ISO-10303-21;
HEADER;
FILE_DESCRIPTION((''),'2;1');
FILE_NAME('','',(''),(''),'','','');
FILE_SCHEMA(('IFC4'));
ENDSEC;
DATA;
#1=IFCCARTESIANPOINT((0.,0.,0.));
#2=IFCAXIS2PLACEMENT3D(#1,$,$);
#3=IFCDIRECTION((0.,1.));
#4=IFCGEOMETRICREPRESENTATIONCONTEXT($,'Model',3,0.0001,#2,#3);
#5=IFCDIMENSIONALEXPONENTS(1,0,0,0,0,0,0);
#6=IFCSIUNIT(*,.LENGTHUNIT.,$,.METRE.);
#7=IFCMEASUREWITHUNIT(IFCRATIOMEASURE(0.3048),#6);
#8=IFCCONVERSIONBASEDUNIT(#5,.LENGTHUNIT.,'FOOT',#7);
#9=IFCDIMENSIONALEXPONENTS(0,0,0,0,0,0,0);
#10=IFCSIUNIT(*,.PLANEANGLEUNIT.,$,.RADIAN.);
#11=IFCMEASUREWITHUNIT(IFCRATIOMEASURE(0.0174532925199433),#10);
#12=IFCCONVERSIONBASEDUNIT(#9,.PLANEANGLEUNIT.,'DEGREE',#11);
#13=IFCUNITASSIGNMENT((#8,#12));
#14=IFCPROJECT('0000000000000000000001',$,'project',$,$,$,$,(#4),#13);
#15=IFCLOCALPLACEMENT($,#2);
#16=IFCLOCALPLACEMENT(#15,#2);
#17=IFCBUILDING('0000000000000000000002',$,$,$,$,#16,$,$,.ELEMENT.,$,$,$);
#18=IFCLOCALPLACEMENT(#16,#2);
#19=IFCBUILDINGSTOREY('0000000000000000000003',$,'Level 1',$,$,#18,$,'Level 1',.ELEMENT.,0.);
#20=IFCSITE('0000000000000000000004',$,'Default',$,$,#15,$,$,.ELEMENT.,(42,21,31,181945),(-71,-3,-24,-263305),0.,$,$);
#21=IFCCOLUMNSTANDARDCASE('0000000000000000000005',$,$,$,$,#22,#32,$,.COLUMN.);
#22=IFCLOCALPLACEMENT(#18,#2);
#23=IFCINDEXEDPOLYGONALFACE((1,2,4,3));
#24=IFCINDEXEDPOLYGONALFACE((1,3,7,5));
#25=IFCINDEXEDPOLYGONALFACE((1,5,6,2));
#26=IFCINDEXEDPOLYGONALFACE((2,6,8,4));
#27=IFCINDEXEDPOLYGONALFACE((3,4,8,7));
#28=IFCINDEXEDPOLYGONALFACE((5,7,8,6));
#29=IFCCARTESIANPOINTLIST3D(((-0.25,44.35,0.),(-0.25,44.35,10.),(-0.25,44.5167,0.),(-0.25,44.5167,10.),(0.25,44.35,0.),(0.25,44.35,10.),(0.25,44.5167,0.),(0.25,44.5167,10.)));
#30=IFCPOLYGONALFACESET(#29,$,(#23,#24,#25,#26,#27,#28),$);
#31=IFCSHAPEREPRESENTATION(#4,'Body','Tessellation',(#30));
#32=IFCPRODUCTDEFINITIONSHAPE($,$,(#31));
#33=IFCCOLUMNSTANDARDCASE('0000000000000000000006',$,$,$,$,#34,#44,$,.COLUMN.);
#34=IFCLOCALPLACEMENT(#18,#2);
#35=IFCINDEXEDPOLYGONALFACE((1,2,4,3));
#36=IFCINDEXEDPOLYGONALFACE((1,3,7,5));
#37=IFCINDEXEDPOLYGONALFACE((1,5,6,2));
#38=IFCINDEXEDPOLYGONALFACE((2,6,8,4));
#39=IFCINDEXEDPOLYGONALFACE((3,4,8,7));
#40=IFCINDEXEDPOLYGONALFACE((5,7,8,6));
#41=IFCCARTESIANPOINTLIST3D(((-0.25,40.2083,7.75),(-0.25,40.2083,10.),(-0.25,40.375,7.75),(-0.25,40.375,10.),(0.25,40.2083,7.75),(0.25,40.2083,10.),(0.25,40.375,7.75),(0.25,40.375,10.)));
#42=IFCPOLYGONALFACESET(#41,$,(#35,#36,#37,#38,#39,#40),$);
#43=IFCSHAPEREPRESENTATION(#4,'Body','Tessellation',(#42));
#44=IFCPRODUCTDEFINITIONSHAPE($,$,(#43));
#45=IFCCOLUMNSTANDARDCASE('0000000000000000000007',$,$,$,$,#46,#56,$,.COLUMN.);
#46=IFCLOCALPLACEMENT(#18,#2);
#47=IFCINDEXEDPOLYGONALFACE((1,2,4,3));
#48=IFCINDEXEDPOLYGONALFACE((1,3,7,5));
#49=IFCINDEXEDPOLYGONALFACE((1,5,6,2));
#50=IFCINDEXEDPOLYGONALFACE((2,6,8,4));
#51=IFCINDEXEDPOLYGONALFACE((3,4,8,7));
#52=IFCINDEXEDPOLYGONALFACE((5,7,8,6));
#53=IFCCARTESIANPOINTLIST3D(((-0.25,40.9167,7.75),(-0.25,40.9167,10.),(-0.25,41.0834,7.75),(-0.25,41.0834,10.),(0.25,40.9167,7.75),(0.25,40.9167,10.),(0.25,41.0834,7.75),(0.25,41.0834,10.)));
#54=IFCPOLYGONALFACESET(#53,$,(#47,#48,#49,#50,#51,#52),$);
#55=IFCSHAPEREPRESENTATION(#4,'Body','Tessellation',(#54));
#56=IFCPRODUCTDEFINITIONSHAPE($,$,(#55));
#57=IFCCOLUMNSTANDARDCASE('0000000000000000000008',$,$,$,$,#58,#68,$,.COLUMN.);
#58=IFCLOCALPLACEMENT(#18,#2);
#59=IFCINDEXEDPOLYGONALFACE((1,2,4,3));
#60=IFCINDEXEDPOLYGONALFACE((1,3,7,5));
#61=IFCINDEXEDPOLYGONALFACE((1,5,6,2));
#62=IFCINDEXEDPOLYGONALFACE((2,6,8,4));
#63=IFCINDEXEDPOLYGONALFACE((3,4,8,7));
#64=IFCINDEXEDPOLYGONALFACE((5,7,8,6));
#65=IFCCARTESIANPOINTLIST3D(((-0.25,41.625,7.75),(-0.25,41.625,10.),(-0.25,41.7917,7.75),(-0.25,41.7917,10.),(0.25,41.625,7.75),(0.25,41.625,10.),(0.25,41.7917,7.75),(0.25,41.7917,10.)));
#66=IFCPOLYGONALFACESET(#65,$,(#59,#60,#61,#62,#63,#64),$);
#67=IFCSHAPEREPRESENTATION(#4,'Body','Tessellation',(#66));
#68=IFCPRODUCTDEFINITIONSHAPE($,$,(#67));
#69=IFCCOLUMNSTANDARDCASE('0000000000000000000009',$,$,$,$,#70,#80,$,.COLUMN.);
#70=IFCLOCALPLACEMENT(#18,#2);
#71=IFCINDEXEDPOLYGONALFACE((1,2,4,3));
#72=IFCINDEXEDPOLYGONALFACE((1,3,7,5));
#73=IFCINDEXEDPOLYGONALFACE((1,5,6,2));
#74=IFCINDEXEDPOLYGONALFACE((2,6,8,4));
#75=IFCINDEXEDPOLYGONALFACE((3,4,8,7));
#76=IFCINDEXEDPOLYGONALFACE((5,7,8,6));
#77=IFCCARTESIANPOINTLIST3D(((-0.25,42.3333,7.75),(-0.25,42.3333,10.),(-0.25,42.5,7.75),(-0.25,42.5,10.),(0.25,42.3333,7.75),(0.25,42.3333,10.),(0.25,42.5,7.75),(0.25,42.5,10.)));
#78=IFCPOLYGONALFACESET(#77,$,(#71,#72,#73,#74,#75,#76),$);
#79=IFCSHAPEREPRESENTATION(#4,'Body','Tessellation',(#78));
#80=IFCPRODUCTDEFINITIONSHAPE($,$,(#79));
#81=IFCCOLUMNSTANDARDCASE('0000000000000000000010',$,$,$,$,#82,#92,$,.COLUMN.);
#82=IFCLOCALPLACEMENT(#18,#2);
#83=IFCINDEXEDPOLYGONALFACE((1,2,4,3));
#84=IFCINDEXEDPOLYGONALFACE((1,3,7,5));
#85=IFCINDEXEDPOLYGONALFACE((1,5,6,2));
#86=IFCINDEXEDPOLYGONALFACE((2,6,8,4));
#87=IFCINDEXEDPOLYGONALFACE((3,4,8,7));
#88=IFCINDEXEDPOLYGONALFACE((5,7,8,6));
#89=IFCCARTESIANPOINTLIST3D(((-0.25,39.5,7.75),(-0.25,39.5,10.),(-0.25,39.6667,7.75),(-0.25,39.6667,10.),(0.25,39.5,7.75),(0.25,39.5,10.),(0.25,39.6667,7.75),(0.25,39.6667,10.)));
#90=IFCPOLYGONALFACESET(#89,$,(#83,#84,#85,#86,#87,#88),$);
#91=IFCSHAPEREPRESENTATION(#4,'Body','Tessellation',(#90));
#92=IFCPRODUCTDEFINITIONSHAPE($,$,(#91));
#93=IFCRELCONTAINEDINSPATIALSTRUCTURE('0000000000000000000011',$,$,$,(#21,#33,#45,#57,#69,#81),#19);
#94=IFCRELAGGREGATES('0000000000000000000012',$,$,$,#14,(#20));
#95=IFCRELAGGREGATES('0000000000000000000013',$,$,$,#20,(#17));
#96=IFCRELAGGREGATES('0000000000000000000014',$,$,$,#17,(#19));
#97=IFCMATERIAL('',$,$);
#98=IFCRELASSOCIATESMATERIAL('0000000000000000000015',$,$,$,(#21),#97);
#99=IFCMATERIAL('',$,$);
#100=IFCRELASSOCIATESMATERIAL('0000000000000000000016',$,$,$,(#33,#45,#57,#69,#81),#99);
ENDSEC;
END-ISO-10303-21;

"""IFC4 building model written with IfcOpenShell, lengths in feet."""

from ifc_helpers import new_model, entity, si_unit, converted_unit, direction, frame, origin, place, context, project, spatial, rectangle, extrude, material, element, save


model = new_model("IFC4")

# Units and contexts
model_context = context("Model", 3, precision=0.0001, world=origin(), true_north=direction((0.0, 1.0)))
ifc_project = project(units=[converted_unit("LENGTHUNIT", "FOOT", entity("IfcRatioMeasure", 0.3048), si_unit("LENGTHUNIT", "METRE"), dimensions=[1, 0, 0, 0, 0, 0, 0]), converted_unit("PLANEANGLEUNIT", "DEGREE", entity("IfcRatioMeasure", 0.0174532925199433), si_unit("PLANEANGLEUNIT", "RADIAN"), dimensions=[0, 0, 0, 0, 0, 0, 0])], contexts=[model_context])

# Site, building, storey
site_placement = place(None, origin())
site = spatial("IfcSite", under=ifc_project, at=site_placement, Name="Default", CompositionType="ELEMENT", RefLatitude=(42, 21, 31, 181945), RefLongitude=(-71, -3, -24, -263305), RefElevation=0.0)
building_placement = place(site_placement, origin())
building = spatial("IfcBuilding", under=site, at=building_placement, CompositionType="ELEMENT")
storey_placement = place(building_placement, origin())
storey = spatial("IfcBuildingStorey", under=building, at=storey_placement, Name="Level 1", LongName="Level 1", CompositionType="ELEMENT", Elevation=0.0)

# Columns
ifc_material_1 = material(Name="")
placement = place(storey_placement, frame((0.0, -0.25, 0.0), z_axis=(0.0, 0.0, 1.0), x_axis=(0.0, 1.0, 0.0)))
column_placement = place(placement, frame((44.6833, 0.0, 0.0), z_axis=(0.0, 0.0, 1.0), x_axis=(1.0, 0.0, 0.0)))
element("IfcColumnStandardCase", 1, at=column_placement, inside=storey, material=ifc_material_1, PredefinedType="COLUMN", context=model_context, shape_type="SweptSolid", body=[
    extrude(rectangle(XDim=0.1667, YDim=0.5), origin(), (0.0, 0.0, 1.0), 10.0),
])
ifc_material_2 = material(Name="")
for number, where, z_axis, x_axis in (
    (2, (40.5417, 0.0, 7.75), (0.0, 0.0, 1.0), (1.0, 0.0, 0.0)),
    (3, (41.25, 0.0, 7.75), (0.0, 0.0, 1.0), (1.0, 0.0, 0.0)),
    (4, (41.9583, 0.0, 7.75), (0.0, 0.0, 1.0), (1.0, 0.0, 0.0)),
    (5, (42.6667, 0.0, 7.75), (0.0, 0.0, 1.0), (1.0, 0.0, 0.0)),
    (6, (39.8334, 0.0, 7.75), (0.0, 0.0, 1.0), (1.0, 0.0, 0.0)),
):
    element("IfcColumnStandardCase", number, at=place(placement, frame(where, z_axis=z_axis, x_axis=x_axis)), inside=storey, material=ifc_material_2, PredefinedType="COLUMN", context=model_context, shape_type="SweptSolid", body=[
        extrude(rectangle(XDim=0.1667, YDim=0.5), origin(), (0.0, 0.0, 1.0), 2.25),
    ])

save(model, "model.ifc")
